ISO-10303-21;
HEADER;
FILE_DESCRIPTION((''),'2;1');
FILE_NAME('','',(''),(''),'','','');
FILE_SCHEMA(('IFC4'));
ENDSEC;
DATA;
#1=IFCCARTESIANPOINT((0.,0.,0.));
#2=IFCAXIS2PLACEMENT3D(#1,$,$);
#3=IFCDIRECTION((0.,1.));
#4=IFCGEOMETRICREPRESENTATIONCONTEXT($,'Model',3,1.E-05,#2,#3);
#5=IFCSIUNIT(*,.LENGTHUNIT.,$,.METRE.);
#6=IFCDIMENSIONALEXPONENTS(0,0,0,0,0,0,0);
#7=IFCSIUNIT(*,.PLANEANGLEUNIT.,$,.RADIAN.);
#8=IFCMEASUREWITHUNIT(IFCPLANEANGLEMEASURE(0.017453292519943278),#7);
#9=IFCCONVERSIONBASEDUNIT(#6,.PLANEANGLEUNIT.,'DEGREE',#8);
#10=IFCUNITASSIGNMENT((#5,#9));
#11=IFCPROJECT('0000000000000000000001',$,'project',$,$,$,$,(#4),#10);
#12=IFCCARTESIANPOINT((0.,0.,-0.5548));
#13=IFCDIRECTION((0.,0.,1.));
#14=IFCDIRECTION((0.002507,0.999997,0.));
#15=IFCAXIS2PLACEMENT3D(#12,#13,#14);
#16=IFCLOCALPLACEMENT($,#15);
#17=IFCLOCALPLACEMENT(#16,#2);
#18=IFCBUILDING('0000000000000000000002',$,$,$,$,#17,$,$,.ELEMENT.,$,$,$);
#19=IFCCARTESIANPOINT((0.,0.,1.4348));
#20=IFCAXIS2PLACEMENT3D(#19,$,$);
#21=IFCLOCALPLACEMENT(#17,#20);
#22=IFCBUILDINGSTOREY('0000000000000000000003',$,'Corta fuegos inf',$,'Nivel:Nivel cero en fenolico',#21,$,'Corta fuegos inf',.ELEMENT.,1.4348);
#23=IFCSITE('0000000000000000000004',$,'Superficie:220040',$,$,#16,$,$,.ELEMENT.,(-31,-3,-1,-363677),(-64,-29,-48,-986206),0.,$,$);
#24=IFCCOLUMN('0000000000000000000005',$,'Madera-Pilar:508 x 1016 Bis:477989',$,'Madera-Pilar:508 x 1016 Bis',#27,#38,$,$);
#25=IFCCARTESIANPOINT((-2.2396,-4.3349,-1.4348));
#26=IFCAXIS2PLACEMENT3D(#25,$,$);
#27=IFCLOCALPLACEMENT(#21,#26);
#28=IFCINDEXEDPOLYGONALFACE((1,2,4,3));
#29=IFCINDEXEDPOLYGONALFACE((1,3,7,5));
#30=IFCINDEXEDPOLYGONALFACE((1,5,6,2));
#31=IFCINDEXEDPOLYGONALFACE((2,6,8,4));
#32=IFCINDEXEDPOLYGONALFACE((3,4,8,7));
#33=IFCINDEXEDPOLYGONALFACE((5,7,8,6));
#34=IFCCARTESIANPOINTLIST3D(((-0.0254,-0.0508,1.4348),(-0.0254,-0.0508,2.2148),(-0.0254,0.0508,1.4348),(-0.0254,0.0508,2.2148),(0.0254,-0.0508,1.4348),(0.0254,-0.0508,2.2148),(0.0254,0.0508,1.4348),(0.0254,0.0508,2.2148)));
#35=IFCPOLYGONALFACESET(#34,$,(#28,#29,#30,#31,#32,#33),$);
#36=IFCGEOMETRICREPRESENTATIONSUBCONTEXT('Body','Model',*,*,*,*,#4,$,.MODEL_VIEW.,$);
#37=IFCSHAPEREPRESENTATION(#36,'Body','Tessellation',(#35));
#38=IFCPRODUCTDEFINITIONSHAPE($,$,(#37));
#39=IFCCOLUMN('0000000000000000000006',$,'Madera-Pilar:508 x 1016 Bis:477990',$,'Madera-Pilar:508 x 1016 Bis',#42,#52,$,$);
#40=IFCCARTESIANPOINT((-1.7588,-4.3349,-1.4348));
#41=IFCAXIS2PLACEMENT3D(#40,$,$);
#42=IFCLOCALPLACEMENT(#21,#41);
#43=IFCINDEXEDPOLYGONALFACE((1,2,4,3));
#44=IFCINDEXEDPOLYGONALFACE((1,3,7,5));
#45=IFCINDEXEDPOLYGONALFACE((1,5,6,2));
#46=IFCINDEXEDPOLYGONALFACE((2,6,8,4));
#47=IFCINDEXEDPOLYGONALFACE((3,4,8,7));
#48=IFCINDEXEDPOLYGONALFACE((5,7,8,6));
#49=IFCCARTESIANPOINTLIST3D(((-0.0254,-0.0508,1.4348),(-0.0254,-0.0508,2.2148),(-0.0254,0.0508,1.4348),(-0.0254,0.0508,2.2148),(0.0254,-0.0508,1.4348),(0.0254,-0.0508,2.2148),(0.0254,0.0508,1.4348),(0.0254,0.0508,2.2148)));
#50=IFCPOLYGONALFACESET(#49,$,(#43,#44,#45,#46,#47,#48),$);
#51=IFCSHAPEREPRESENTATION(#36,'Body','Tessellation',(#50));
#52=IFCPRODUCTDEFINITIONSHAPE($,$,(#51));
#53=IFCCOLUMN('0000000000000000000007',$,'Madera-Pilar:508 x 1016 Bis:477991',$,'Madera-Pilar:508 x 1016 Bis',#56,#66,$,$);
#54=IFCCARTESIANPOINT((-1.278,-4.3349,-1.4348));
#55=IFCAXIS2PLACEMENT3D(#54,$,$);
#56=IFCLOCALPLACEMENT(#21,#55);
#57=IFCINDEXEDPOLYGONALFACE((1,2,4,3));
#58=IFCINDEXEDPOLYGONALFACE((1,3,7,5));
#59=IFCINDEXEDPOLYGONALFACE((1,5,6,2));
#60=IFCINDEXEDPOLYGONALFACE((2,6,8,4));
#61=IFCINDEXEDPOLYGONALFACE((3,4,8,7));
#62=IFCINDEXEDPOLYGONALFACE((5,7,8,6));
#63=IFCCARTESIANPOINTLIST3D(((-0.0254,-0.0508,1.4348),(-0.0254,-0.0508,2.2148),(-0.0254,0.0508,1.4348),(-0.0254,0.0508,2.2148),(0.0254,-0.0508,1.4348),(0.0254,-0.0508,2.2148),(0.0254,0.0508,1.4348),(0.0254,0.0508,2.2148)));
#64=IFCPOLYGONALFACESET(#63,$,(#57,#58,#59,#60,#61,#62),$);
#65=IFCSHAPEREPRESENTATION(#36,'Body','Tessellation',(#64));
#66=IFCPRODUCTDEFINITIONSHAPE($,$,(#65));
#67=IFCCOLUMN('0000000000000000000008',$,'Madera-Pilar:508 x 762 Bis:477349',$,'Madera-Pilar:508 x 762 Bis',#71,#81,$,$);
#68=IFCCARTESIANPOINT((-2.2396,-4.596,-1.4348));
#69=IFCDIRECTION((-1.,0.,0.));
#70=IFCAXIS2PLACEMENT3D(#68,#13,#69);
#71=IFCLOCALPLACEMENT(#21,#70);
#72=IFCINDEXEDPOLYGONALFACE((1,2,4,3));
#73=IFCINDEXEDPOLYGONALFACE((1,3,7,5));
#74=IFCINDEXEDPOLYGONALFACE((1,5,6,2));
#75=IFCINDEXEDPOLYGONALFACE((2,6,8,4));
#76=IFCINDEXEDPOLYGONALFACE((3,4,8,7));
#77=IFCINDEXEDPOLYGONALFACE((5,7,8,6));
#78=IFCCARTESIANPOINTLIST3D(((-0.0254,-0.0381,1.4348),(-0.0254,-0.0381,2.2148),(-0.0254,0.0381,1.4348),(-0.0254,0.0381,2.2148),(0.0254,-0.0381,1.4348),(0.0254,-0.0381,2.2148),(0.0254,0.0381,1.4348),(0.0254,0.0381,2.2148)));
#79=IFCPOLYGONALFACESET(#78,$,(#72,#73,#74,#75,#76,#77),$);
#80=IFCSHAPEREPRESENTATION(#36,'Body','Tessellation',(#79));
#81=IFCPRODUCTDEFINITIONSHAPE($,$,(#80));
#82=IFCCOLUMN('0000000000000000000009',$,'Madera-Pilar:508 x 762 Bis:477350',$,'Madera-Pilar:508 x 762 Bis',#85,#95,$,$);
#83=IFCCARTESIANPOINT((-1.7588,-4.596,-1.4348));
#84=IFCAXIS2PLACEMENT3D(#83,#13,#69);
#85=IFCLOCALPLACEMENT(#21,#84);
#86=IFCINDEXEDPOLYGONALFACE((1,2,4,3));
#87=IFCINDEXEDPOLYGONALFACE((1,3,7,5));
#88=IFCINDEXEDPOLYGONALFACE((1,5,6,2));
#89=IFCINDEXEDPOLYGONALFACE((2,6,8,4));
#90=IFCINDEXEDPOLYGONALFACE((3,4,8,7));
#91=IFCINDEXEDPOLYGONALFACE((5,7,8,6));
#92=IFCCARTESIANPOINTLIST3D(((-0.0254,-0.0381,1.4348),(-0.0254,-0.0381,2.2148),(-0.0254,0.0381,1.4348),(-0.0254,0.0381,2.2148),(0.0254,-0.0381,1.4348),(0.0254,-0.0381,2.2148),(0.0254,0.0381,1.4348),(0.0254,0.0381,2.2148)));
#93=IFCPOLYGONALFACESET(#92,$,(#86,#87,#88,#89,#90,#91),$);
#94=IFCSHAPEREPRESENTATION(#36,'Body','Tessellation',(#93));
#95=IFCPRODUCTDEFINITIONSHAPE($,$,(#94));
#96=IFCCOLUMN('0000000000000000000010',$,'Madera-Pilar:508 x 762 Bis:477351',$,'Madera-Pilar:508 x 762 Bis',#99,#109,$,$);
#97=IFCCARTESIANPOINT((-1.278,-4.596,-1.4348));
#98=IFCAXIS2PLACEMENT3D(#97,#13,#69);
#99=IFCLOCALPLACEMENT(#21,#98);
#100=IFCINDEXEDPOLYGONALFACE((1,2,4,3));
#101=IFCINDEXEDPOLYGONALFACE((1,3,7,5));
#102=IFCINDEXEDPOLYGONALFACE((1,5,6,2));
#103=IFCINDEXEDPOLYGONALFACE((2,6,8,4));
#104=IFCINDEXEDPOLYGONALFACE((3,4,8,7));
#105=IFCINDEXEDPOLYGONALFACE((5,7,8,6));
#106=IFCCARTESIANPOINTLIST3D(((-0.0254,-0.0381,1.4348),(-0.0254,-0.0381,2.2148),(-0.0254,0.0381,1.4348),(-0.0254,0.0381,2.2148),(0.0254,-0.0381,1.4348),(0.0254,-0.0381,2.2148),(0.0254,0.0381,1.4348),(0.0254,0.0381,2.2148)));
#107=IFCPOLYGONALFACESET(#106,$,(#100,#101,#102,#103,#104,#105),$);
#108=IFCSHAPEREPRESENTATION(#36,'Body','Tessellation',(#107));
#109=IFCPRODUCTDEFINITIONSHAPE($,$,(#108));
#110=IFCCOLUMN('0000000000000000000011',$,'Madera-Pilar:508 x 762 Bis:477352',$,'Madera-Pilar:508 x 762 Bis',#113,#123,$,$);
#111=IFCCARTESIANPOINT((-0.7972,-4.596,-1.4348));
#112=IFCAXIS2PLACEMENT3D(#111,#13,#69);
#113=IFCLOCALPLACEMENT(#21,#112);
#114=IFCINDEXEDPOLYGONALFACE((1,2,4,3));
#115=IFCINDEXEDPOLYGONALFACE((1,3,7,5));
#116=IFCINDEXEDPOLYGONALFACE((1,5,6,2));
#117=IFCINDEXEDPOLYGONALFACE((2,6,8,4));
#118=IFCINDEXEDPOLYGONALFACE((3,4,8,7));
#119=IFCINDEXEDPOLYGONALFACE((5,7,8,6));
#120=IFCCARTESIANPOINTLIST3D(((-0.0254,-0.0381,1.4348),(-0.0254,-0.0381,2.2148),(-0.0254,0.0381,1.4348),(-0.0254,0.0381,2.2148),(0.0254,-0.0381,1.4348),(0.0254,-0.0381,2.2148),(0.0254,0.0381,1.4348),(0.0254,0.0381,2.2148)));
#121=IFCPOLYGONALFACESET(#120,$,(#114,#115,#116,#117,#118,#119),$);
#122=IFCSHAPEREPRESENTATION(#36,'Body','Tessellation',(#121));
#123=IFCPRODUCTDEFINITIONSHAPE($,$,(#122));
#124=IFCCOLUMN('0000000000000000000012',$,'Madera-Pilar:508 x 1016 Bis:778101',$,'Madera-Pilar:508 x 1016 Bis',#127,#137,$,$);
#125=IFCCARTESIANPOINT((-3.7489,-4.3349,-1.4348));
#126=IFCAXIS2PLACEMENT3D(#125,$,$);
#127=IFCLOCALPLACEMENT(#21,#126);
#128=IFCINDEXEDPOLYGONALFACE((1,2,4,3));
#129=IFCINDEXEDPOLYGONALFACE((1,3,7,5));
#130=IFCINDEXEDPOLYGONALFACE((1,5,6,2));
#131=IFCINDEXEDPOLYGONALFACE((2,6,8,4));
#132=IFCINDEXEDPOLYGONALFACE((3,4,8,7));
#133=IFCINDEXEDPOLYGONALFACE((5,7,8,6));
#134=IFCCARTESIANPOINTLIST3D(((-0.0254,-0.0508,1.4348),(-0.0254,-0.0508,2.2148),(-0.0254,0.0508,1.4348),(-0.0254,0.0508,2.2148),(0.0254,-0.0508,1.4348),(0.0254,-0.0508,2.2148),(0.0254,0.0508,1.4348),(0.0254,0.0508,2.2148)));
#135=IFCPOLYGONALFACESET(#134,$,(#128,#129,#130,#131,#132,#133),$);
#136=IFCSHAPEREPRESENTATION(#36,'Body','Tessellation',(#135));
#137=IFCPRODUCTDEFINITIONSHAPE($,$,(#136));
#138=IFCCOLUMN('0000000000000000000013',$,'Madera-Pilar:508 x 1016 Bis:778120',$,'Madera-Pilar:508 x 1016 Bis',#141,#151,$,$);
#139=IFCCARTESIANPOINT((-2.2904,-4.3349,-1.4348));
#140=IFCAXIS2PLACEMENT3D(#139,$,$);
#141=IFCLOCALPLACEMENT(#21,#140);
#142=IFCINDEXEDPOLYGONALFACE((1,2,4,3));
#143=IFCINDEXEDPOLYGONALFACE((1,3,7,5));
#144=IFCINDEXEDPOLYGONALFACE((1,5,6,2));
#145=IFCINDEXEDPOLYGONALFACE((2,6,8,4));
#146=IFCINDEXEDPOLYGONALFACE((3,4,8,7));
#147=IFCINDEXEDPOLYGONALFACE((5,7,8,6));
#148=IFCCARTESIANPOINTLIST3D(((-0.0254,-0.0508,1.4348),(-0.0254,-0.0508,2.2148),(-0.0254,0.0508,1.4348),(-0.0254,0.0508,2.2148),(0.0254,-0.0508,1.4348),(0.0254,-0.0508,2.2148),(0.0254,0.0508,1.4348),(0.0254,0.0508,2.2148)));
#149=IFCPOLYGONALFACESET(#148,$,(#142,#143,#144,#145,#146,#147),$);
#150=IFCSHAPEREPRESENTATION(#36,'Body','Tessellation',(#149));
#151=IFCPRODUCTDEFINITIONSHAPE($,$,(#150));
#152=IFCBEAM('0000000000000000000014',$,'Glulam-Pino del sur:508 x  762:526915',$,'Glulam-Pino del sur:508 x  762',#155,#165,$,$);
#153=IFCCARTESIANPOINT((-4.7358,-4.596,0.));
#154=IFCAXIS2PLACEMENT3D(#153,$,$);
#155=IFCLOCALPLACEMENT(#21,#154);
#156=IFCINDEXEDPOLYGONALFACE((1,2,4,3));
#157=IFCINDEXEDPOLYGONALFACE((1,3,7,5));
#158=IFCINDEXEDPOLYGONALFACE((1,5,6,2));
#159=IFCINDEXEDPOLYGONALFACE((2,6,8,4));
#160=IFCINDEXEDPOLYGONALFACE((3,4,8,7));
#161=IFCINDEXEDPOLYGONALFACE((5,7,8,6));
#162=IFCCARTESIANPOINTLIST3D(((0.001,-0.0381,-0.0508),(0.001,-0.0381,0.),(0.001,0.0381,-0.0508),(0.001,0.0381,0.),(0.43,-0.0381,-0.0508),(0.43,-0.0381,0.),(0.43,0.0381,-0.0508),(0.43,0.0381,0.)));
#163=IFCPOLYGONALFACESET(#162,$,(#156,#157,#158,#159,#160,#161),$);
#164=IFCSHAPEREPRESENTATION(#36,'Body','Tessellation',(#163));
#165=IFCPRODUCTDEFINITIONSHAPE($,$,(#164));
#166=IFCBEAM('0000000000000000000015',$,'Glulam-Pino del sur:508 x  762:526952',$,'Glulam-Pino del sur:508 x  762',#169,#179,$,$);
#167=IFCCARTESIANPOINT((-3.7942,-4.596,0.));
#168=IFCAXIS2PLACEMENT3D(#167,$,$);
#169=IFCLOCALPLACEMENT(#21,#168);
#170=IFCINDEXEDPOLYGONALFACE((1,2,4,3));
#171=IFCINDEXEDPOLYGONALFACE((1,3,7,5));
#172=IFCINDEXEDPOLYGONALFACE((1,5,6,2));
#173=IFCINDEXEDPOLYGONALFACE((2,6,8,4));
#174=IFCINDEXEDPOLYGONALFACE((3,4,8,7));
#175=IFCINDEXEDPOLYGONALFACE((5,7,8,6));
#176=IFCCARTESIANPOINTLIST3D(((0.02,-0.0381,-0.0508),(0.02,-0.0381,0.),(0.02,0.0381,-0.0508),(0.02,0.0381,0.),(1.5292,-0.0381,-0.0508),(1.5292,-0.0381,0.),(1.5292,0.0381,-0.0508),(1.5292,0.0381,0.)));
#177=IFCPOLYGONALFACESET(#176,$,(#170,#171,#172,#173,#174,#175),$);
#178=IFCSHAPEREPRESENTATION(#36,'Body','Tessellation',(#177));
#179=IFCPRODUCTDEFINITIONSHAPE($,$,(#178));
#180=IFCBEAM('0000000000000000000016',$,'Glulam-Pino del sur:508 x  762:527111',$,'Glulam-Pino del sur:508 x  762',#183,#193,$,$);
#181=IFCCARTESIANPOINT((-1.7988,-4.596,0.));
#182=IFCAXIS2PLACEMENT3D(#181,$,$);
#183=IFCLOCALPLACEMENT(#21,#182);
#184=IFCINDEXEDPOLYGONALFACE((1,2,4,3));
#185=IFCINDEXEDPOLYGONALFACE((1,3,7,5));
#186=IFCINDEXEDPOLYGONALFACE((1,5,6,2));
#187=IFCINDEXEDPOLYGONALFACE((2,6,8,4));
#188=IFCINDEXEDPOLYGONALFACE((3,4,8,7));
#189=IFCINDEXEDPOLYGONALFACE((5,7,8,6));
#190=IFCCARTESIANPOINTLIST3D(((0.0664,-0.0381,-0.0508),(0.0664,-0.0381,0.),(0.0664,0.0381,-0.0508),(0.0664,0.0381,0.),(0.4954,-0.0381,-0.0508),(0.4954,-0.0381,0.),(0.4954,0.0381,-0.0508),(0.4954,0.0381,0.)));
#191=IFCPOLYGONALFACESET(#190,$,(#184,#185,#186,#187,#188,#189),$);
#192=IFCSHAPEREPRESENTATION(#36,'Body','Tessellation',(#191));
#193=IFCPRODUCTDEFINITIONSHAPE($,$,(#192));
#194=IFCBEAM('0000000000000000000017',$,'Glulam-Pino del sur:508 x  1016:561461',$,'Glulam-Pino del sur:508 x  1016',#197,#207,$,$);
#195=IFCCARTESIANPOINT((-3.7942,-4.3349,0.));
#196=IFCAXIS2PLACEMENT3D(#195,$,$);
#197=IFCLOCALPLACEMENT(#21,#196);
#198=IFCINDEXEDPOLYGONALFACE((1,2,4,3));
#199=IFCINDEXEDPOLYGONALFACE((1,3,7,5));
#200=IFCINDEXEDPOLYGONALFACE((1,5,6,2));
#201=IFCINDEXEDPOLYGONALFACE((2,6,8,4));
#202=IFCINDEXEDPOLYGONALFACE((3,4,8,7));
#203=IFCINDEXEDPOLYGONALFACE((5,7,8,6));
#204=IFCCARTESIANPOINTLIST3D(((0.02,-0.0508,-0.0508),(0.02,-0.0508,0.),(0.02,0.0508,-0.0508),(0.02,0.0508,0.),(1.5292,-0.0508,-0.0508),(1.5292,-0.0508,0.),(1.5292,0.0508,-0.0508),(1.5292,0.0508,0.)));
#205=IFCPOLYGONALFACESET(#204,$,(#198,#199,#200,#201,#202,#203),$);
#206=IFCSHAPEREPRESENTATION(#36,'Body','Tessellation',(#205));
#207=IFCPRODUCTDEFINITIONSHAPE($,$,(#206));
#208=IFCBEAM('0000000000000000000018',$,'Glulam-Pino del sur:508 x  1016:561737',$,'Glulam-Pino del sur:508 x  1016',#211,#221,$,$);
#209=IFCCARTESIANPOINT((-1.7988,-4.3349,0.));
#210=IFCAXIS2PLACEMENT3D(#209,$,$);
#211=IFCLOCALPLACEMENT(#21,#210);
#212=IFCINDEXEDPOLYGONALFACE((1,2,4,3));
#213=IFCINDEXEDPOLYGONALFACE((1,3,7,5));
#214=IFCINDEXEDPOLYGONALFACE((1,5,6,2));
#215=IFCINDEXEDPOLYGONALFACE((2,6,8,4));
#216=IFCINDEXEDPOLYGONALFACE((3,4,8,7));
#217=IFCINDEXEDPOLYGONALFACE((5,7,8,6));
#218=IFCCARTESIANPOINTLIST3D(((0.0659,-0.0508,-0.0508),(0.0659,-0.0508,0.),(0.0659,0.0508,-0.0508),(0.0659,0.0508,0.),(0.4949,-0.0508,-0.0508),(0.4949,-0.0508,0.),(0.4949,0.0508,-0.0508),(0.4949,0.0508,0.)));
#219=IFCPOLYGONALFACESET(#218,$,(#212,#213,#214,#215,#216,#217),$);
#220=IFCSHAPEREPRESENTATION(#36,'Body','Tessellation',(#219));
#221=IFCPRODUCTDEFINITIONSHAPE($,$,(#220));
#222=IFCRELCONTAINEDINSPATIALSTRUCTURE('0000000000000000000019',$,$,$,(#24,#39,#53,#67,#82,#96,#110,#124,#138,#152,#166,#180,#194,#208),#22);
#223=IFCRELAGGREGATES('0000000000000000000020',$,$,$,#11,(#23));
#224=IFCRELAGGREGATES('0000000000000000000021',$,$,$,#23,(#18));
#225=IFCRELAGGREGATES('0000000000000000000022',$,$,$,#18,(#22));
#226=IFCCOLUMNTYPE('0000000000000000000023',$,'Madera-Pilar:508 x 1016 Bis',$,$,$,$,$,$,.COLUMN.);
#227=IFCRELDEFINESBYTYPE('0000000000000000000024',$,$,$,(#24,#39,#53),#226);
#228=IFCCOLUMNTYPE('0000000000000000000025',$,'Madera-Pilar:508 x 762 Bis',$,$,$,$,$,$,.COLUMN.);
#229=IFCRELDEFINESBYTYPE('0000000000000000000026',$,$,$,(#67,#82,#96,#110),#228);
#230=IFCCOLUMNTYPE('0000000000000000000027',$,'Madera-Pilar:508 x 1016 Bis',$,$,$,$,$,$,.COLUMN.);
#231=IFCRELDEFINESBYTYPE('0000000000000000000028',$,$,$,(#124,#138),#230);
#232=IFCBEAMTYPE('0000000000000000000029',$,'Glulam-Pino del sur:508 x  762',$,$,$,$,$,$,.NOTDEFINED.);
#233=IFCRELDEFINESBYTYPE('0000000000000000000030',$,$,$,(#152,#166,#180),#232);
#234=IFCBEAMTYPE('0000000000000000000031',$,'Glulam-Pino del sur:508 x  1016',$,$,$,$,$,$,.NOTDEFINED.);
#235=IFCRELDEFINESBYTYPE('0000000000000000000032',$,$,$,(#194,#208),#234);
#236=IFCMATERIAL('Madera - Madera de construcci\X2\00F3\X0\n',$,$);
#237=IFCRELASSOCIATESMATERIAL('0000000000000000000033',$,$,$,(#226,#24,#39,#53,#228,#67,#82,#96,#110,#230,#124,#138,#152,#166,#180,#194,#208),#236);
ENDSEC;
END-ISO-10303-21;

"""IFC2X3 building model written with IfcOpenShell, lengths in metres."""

from ifc_helpers import new_model, entity, si_unit, converted_unit, direction, frame, frame_2d, origin, origin_2d_with_axis, place, context, subcontext, project, spatial, rectangle, extrude, source, transform, mapped, material, type_object, type_shapes, element, save


model = new_model("IFC2X3")

# Units and contexts
model_context = context("Model", 3, precision=1e-05, world=origin(), true_north=direction((0.0, 1.0)))
body_context = subcontext(model_context, "Body", "Model", "MODEL_VIEW")
ifc_project = project(units=[si_unit("LENGTHUNIT", "METRE"), converted_unit("PLANEANGLEUNIT", "DEGREE", entity("IfcPlaneAngleMeasure", 0.017453292519943278), si_unit("PLANEANGLEUNIT", "RADIAN"), dimensions=[0, 0, 0, 0, 0, 0, 0])], contexts=[model_context])

# Site, building, storey
site_placement = place(None, frame((0.0, 0.0, -0.5548), z_axis=(0.0, 0.0, 1.0), x_axis=(0.002507, 0.999997, 0.0)))
site = spatial("IfcSite", under=ifc_project, at=site_placement, Name="Superficie:220040", CompositionType="ELEMENT", RefLatitude=(-31, -3, -1, -363677), RefLongitude=(-64, -29, -48, -986206), RefElevation=0.0)
building_placement = place(site_placement, origin())
building = spatial("IfcBuilding", under=site, at=building_placement, CompositionType="ELEMENT")
storey_placement = place(building_placement, frame((0.0, 0.0, 1.4348)))
storey = spatial("IfcBuildingStorey", under=building, at=storey_placement, Name="Corta fuegos inf", ObjectType="Nivel:Nivel cero en fenolico", LongName="Corta fuegos inf", CompositionType="ELEMENT", Elevation=1.4348)

# Columns
ifc_material_1 = material(Name="Madera - Madera de construcción")
column_type_1 = type_object("IfcColumnType", Name="Madera-Pilar:508 x 1016 Bis", PredefinedType="COLUMN", material=ifc_material_1)
shared_shape_1 = source(origin(), body_context, "Body", "SweptSolid", [
    extrude(rectangle(XDim=0.0508, YDim=0.1016, at=origin_2d_with_axis()), frame((0.0, 0.0, 1.4348), z_axis=(0.0, 0.0, 1.0), x_axis=(-1.0, 0.0, 0.0)), (0.0, 0.0, 1.0), 0.78),
])
type_shapes(column_type_1, [shared_shape_1])
for number, where, name in (
    (1, (-2.2396, -4.3349, -1.4348), "Madera-Pilar:508 x 1016 Bis:477989"),
    (2, (-1.7588, -4.3349, -1.4348), "Madera-Pilar:508 x 1016 Bis:477990"),
    (3, (-1.278, -4.3349, -1.4348), "Madera-Pilar:508 x 1016 Bis:477991"),
):
    element("IfcColumn", number, at=place(storey_placement, frame(where)), inside=storey, type_object=column_type_1, material=ifc_material_1, Name=name, ObjectType="Madera-Pilar:508 x 1016 Bis", context=body_context, shape_type="MappedRepresentation", body=[
        mapped(shared_shape_1, transform((0.0, 0.0, 0.0), scale=1.0)),
    ])
column_type_2 = type_object("IfcColumnType", Name="Madera-Pilar:508 x 762 Bis", PredefinedType="COLUMN", material=ifc_material_1)
shared_shape_2 = source(origin(), body_context, "Body", "SweptSolid", [
    extrude(rectangle(XDim=0.0508, YDim=0.0762, at=origin_2d_with_axis()), frame((0.0, 0.0, 1.4348), z_axis=(0.0, 0.0, 1.0), x_axis=(-1.0, 0.0, 0.0)), (0.0, 0.0, 1.0), 0.78),
])
type_shapes(column_type_2, [shared_shape_2])
for number, where, z_axis, x_axis, name in (
    (4, (-2.2396, -4.596, -1.4348), (0.0, 0.0, 1.0), (-1.0, 0.0, 0.0), "Madera-Pilar:508 x 762 Bis:477349"),
    (5, (-1.7588, -4.596, -1.4348), (0.0, 0.0, 1.0), (-1.0, 0.0, 0.0), "Madera-Pilar:508 x 762 Bis:477350"),
    (6, (-1.278, -4.596, -1.4348), (0.0, 0.0, 1.0), (-1.0, 0.0, 0.0), "Madera-Pilar:508 x 762 Bis:477351"),
    (7, (-0.7972, -4.596, -1.4348), (0.0, 0.0, 1.0), (-1.0, 0.0, 0.0), "Madera-Pilar:508 x 762 Bis:477352"),
):
    element("IfcColumn", number, at=place(storey_placement, frame(where, z_axis=z_axis, x_axis=x_axis)), inside=storey, type_object=column_type_2, material=ifc_material_1, Name=name, ObjectType="Madera-Pilar:508 x 762 Bis", context=body_context, shape_type="MappedRepresentation", body=[
        mapped(shared_shape_2, transform((0.0, 0.0, 0.0), scale=1.0)),
    ])
column_type_3 = type_object("IfcColumnType", Name="Madera-Pilar:508 x 1016 Bis", PredefinedType="COLUMN", material=ifc_material_1)
shared_shape_3 = source(origin(), body_context, "Body", "SweptSolid", [
    extrude(rectangle(XDim=0.0508, YDim=0.1016, at=origin_2d_with_axis()), frame((0.0, 0.0, 1.4348), z_axis=(0.0, 0.0, 1.0), x_axis=(-1.0, 0.0, 0.0)), (0.0, 0.0, 1.0), 0.78),
])
type_shapes(column_type_3, [shared_shape_3])
for number, where, name in (
    (8, (-3.7489, -4.3349, -1.4348), "Madera-Pilar:508 x 1016 Bis:778101"),
    (9, (-2.2904, -4.3349, -1.4348), "Madera-Pilar:508 x 1016 Bis:778120"),
):
    element("IfcColumn", number, at=place(storey_placement, frame(where)), inside=storey, type_object=column_type_3, material=ifc_material_1, Name=name, ObjectType="Madera-Pilar:508 x 1016 Bis", context=body_context, shape_type="MappedRepresentation", body=[
        mapped(shared_shape_3, transform((0.0, 0.0, 0.0), scale=1.0)),
    ])

# Beams
beam_type_1 = type_object("IfcBeamType", Name="Glulam-Pino del sur:508 x  762", PredefinedType="NOTDEFINED")
beam_1_placement = place(storey_placement, frame((-4.7358, -4.596, 0.0)))
element("IfcBeam", 10, at=beam_1_placement, inside=storey, type_object=beam_type_1, material=ifc_material_1, Name="Glulam-Pino del sur:508 x  762:526915", ObjectType="Glulam-Pino del sur:508 x  762", context=body_context, shape_type="SweptSolid", body=[
    extrude(rectangle(XDim=0.0508, YDim=0.0762, at=frame_2d((0.0, 0.0), x_axis=(1.0, 0.0))), frame((0.001, 0.0, -0.0254), z_axis=(1.0, 0.0, 0.0), x_axis=(0.0, 0.0, -1.0)), (0.0, 0.0, 1.0), 0.429),
])
beam_2_placement = place(storey_placement, frame((-3.7942, -4.596, 0.0)))
element("IfcBeam", 11, at=beam_2_placement, inside=storey, type_object=beam_type_1, material=ifc_material_1, Name="Glulam-Pino del sur:508 x  762:526952", ObjectType="Glulam-Pino del sur:508 x  762", context=body_context, shape_type="SweptSolid", body=[
    extrude(rectangle(XDim=0.0508, YDim=0.0762, at=frame_2d((0.0, 0.0), x_axis=(1.0, 0.0))), frame((0.02, 0.0, -0.0254), z_axis=(1.0, 0.0, 0.0), x_axis=(0.0, 0.0, -1.0)), (0.0, 0.0, 1.0), 1.5092),
])
beam_3_placement = place(storey_placement, frame((-1.7988, -4.596, 0.0)))
element("IfcBeam", 12, at=beam_3_placement, inside=storey, type_object=beam_type_1, material=ifc_material_1, Name="Glulam-Pino del sur:508 x  762:527111", ObjectType="Glulam-Pino del sur:508 x  762", context=body_context, shape_type="SweptSolid", body=[
    extrude(rectangle(XDim=0.0508, YDim=0.0762, at=frame_2d((0.0, 0.0), x_axis=(1.0, 0.0))), frame((0.0664, 0.0, -0.0254), z_axis=(1.0, 0.0, 0.0), x_axis=(0.0, 0.0, -1.0)), (0.0, 0.0, 1.0), 0.429),
])
beam_type_2 = type_object("IfcBeamType", Name="Glulam-Pino del sur:508 x  1016", PredefinedType="NOTDEFINED")
beam_4_placement = place(storey_placement, frame((-3.7942, -4.3349, 0.0)))
element("IfcBeam", 13, at=beam_4_placement, inside=storey, type_object=beam_type_2, material=ifc_material_1, Name="Glulam-Pino del sur:508 x  1016:561461", ObjectType="Glulam-Pino del sur:508 x  1016", context=body_context, shape_type="SweptSolid", body=[
    extrude(rectangle(XDim=0.0508, YDim=0.1016, at=frame_2d((0.0, 0.0), x_axis=(1.0, 0.0))), frame((0.02, 0.0, -0.0254), z_axis=(1.0, 0.0, 0.0), x_axis=(0.0, 0.0, -1.0)), (0.0, 0.0, 1.0), 1.5092),
])
beam_5_placement = place(storey_placement, frame((-1.7988, -4.3349, 0.0)))
element("IfcBeam", 14, at=beam_5_placement, inside=storey, type_object=beam_type_2, material=ifc_material_1, Name="Glulam-Pino del sur:508 x  1016:561737", ObjectType="Glulam-Pino del sur:508 x  1016", context=body_context, shape_type="SweptSolid", body=[
    extrude(rectangle(XDim=0.0508, YDim=0.1016, at=frame_2d((0.0, 0.0), x_axis=(1.0, 0.0))), frame((0.0659, 0.0, -0.0254), z_axis=(1.0, 0.0, 0.0), x_axis=(0.0, 0.0, -1.0)), (0.0, 0.0, 1.0), 0.429),
])

save(model, "model.ifc")
